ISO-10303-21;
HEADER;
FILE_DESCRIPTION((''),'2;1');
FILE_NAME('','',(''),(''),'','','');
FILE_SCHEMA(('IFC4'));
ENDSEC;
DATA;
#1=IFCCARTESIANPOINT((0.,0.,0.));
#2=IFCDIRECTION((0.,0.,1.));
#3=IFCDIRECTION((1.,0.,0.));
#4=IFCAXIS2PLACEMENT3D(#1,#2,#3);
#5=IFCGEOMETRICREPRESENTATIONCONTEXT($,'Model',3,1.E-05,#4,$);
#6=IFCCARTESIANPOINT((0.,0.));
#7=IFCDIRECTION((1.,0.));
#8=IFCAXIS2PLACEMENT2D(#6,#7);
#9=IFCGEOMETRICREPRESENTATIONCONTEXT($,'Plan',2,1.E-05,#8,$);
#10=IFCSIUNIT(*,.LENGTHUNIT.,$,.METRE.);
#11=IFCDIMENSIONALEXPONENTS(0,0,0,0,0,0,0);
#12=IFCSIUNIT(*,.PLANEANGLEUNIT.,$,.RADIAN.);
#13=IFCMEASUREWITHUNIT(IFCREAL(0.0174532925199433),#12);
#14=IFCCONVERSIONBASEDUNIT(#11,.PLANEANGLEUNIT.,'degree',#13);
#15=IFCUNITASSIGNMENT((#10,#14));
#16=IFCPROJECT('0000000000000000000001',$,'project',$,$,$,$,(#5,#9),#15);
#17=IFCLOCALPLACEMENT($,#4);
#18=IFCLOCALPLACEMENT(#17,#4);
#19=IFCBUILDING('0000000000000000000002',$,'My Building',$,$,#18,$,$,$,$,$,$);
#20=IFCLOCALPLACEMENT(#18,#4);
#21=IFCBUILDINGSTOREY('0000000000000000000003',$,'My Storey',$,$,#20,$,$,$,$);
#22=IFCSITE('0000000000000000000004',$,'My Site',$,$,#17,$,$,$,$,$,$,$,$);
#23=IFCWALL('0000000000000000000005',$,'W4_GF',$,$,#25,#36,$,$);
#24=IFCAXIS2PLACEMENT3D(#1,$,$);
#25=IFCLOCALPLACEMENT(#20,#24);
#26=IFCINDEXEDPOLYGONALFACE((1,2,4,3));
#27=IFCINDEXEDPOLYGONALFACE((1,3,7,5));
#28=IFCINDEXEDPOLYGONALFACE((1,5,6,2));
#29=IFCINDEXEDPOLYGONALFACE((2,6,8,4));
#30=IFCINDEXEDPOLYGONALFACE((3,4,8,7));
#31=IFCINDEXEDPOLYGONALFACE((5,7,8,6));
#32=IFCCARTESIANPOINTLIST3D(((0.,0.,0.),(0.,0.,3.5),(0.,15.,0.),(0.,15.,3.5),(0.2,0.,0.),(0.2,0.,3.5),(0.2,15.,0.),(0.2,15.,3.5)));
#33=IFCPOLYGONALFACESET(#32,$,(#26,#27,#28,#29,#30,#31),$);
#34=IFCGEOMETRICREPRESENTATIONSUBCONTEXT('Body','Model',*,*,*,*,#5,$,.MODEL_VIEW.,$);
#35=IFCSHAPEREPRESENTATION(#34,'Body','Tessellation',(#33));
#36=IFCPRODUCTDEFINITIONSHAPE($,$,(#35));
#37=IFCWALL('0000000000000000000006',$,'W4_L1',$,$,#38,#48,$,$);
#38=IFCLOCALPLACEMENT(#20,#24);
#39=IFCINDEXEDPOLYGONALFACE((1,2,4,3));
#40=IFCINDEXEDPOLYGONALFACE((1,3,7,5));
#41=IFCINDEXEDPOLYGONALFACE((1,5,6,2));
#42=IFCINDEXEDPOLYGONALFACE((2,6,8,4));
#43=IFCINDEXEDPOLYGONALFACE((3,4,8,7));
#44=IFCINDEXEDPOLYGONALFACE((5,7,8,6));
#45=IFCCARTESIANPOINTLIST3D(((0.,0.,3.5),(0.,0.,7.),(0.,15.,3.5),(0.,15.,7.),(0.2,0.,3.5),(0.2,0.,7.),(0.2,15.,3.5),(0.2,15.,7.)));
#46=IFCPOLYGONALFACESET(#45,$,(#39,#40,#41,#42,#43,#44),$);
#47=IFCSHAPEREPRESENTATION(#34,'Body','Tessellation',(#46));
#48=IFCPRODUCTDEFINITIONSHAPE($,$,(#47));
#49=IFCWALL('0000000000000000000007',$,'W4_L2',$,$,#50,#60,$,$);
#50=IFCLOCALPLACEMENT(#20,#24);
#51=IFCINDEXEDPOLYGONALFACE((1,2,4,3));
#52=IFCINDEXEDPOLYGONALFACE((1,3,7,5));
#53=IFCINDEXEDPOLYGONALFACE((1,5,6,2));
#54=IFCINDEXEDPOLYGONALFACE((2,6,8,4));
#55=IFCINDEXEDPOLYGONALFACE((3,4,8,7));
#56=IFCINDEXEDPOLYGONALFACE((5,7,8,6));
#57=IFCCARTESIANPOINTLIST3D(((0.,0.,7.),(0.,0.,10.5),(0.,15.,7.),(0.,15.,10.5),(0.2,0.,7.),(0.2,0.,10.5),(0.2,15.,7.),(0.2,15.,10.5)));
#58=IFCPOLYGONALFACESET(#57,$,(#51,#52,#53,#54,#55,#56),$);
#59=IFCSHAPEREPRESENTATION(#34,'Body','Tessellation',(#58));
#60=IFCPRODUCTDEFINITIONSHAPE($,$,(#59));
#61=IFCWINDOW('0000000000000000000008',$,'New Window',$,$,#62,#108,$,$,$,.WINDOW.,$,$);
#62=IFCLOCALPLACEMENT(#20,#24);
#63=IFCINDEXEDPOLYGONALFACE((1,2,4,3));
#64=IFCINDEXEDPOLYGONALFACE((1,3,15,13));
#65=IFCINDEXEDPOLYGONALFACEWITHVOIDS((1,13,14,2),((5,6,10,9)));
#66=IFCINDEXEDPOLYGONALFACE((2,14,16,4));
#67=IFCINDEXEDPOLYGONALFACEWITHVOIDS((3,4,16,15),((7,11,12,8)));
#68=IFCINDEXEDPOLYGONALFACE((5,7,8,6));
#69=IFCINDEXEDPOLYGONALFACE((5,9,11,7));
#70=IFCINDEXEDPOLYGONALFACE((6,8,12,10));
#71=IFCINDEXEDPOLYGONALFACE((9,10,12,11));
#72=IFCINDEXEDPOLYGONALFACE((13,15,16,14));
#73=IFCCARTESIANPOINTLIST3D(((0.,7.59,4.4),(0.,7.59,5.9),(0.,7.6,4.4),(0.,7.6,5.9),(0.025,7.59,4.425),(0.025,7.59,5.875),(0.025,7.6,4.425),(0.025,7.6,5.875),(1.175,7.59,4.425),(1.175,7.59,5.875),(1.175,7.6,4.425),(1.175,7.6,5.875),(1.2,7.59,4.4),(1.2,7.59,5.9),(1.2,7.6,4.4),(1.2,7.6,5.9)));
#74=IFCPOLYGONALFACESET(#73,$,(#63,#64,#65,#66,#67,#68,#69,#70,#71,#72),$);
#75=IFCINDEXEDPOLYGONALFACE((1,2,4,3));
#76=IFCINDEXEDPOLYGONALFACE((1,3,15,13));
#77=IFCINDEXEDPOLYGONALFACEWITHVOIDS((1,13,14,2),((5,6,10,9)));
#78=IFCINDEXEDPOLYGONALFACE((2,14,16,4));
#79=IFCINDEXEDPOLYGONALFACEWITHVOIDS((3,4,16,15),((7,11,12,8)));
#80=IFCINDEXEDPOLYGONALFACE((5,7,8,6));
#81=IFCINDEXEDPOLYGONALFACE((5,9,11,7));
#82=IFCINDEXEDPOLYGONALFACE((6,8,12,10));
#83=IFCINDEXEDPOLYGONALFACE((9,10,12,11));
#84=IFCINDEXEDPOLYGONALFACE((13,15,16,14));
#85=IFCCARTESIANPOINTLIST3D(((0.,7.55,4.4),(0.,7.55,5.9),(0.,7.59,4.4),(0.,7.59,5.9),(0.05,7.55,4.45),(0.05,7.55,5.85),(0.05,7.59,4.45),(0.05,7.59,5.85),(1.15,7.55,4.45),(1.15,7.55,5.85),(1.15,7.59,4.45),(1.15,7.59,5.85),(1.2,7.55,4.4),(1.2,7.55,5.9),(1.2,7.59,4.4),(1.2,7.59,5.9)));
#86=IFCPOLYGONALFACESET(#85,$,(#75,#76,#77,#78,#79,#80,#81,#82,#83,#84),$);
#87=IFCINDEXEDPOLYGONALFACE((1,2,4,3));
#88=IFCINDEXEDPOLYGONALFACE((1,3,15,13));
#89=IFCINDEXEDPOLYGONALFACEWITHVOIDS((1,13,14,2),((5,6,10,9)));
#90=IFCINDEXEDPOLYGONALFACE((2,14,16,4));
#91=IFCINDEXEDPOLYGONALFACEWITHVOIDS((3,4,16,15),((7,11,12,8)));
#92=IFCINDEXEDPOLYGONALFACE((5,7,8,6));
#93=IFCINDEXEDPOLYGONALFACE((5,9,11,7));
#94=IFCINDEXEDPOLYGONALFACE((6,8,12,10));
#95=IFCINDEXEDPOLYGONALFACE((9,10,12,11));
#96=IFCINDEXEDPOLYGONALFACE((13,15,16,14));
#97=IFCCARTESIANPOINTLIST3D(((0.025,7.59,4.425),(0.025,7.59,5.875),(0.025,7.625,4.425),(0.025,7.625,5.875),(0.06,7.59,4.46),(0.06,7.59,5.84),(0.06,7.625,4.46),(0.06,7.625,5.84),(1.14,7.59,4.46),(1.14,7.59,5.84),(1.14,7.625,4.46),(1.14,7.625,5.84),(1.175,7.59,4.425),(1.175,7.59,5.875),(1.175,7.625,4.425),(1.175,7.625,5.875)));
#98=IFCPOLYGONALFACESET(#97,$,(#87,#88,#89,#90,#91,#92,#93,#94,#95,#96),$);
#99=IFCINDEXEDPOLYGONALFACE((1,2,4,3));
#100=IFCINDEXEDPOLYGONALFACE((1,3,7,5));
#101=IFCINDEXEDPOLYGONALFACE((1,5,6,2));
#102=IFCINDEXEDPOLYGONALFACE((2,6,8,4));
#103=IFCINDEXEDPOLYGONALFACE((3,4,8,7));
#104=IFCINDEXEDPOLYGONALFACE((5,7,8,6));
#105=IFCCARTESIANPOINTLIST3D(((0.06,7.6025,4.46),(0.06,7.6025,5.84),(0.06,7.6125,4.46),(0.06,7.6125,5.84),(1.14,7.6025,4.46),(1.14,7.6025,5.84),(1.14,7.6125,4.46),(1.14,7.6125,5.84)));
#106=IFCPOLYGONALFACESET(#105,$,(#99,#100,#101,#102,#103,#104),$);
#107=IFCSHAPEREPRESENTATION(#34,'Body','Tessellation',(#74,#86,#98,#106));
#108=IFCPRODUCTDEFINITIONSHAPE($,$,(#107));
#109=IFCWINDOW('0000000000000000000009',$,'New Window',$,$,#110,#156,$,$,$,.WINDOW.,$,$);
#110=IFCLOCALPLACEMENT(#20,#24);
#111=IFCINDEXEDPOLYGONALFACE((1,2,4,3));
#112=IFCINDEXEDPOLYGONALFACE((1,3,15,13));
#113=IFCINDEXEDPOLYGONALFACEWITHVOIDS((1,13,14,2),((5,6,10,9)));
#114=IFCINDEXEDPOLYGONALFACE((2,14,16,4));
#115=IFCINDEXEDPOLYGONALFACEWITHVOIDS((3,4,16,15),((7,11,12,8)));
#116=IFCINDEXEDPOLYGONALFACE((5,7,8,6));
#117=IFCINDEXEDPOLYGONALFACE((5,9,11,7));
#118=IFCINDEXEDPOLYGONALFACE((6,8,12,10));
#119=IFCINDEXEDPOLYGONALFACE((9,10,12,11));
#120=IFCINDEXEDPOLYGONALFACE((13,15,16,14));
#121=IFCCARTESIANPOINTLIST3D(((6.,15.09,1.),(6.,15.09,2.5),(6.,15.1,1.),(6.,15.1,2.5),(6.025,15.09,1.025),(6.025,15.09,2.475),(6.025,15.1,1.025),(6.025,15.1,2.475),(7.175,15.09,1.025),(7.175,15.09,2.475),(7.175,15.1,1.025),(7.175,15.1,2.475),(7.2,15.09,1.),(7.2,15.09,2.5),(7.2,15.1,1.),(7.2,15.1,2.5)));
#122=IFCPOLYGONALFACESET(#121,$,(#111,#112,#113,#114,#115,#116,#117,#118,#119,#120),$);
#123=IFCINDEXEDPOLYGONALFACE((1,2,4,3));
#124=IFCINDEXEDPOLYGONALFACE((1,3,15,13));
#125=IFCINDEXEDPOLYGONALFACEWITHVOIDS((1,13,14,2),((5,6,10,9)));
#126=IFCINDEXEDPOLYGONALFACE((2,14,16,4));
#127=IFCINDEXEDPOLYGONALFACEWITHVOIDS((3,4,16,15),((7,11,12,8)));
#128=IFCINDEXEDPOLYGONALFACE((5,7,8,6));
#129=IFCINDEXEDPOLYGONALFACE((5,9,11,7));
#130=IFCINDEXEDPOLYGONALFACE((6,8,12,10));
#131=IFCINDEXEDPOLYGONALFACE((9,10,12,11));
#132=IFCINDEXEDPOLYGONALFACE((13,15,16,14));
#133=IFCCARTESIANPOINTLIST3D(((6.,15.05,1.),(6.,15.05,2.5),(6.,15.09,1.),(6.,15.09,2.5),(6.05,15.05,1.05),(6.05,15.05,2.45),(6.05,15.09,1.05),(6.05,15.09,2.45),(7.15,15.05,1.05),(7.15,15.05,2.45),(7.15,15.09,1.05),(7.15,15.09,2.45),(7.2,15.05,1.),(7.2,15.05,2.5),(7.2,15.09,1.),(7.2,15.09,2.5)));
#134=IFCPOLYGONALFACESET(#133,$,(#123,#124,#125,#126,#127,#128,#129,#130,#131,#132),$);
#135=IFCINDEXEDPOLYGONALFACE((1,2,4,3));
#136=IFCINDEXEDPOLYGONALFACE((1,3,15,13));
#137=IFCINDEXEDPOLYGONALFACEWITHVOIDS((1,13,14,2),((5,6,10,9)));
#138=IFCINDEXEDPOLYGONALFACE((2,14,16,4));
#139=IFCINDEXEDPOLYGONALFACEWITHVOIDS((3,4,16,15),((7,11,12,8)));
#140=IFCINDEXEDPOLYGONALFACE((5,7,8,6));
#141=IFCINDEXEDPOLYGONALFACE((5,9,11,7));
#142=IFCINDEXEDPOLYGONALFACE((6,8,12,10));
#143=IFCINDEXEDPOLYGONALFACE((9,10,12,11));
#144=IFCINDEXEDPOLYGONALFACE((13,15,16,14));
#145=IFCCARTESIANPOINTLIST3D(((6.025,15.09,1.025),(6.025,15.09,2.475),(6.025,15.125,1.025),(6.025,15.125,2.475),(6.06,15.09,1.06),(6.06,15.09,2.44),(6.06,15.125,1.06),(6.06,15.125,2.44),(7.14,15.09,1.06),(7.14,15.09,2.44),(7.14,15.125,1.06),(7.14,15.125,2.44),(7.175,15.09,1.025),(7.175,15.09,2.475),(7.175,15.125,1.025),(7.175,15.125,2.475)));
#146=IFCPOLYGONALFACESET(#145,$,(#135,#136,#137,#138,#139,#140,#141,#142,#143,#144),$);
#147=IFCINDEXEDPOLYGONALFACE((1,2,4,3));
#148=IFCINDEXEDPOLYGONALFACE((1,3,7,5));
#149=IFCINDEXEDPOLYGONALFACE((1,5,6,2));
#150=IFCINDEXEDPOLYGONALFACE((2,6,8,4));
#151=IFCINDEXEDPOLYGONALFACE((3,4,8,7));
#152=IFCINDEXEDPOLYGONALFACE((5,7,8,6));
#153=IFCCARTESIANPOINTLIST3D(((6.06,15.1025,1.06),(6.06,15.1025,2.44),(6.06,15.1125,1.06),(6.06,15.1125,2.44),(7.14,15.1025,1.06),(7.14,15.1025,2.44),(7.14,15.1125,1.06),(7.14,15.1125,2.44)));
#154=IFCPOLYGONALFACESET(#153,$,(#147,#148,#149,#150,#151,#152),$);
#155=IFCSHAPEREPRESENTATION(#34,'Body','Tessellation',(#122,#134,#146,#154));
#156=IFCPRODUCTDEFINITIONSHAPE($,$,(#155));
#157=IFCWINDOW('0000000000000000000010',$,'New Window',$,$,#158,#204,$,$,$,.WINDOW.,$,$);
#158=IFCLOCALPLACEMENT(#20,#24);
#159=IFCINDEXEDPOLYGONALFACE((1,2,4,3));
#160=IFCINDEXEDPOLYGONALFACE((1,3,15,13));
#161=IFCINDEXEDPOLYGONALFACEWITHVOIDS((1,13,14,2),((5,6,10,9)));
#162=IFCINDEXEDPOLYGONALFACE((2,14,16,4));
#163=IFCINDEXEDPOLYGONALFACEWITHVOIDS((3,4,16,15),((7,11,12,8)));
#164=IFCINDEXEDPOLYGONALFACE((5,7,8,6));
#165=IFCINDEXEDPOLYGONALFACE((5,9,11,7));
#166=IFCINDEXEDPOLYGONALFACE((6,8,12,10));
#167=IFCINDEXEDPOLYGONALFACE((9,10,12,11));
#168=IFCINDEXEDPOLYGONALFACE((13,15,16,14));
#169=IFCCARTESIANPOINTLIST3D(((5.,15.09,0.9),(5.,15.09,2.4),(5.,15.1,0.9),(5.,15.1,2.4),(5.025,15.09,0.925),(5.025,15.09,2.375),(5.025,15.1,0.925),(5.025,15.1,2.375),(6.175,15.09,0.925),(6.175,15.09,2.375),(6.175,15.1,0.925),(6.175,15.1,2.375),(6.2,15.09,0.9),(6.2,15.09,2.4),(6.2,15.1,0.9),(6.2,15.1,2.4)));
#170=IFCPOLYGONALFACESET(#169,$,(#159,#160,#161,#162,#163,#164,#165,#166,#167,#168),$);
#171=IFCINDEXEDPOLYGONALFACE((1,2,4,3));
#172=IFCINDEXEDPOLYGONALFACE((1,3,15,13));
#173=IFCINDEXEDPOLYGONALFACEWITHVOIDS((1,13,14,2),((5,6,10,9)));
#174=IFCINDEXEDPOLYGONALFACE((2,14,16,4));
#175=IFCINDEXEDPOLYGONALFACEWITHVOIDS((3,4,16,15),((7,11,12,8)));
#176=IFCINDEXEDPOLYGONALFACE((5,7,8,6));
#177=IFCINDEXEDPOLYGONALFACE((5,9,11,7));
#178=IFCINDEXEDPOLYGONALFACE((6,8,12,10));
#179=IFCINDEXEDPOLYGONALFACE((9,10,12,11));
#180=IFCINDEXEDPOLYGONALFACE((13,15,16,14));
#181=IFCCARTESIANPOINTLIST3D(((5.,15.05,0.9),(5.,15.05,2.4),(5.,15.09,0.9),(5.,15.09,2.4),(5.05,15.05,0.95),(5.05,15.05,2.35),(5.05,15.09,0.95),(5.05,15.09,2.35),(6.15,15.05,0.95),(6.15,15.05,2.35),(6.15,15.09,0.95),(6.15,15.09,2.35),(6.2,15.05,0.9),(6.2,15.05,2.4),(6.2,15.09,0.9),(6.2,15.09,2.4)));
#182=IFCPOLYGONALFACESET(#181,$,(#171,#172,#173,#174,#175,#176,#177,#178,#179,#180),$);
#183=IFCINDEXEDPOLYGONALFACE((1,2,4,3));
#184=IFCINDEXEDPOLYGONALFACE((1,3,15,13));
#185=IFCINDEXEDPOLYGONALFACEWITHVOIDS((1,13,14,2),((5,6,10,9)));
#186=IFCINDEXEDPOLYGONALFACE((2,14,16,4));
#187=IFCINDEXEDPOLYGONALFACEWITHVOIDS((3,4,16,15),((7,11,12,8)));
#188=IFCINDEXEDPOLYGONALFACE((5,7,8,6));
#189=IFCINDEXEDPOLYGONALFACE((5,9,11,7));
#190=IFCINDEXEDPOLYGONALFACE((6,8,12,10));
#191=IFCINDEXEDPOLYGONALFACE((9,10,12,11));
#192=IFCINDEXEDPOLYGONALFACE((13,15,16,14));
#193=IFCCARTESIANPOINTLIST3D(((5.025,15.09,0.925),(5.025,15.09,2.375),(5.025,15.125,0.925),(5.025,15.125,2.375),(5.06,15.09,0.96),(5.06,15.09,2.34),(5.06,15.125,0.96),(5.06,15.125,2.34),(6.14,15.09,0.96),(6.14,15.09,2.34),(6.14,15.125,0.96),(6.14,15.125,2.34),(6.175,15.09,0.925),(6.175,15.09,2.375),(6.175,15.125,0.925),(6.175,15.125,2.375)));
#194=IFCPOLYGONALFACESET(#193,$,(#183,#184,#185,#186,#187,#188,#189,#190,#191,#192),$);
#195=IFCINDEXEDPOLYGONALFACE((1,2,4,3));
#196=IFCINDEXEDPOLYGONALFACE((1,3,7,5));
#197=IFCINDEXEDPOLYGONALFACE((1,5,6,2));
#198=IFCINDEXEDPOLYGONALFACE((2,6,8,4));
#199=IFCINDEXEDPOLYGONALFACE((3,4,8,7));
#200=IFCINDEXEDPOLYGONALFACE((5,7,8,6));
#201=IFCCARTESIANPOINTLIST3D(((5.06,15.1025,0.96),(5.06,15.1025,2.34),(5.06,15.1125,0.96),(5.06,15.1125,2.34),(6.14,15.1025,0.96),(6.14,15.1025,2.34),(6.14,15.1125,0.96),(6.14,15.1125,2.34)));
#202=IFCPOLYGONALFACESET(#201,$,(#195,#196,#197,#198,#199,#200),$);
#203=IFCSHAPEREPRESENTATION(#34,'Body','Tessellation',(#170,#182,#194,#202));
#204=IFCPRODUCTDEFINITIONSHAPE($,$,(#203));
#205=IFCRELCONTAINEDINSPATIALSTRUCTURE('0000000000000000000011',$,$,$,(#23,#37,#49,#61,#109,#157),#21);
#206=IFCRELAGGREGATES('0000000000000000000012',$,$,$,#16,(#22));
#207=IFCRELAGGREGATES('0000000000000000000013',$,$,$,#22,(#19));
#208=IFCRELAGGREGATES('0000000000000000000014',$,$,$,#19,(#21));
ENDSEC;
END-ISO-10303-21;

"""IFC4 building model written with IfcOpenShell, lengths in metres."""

from ifc_helpers import new_model, entity, si_unit, converted_unit, frame, origin_with_axes, origin_2d_with_axis, place, context, subcontext, project, spatial, line, indexed_curve, outline, extrude, element, save


model = new_model("IFC4")

# Units and contexts
model_context = context("Model", 3, precision=1e-05, world=origin_with_axes())
plan_context = context("Plan", 2, precision=1e-05, world=origin_2d_with_axis())
body_context = subcontext(model_context, "Body", "Model", "MODEL_VIEW")
ifc_project = project(units=[si_unit("LENGTHUNIT", "METRE"), converted_unit("PLANEANGLEUNIT", "degree", entity("IfcReal", 0.0174532925199433), si_unit("PLANEANGLEUNIT", "RADIAN"), dimensions=[0, 0, 0, 0, 0, 0, 0])], contexts=[model_context, plan_context])

# Site, building, storey
site_placement = place(None, origin_with_axes())
site = spatial("IfcSite", under=ifc_project, at=site_placement, Name="My Site")
building_placement = place(site_placement, origin_with_axes())
building = spatial("IfcBuilding", under=site, at=building_placement, Name="My Building")
storey_placement = place(building_placement, origin_with_axes())
storey = spatial("IfcBuildingStorey", under=building, at=storey_placement, Name="My Storey")

# Walls
for number, where, z_axis, x_axis, name in (
    (1, (0.0, 15.0, 0.0), (0.0, 0.0, 1.0), (0.0, -1.0, 0.0), "W4_GF"),
    (2, (0.0, 15.0, 3.5), (0.0, 0.0, 1.0), (0.0, -1.0, 0.0), "W4_L1"),
    (3, (0.0, 15.0, 7.0), (0.0, 0.0, 1.0), (0.0, -1.0, 0.0), "W4_L2"),
):
    element("IfcWall", number, at=place(storey_placement, frame(where, z_axis=z_axis, x_axis=x_axis)), inside=storey, Name=name, context=body_context, shape_type="SweptSolid", body=[
        extrude(outline(indexed_curve([(0.0, 0.0), (0.0, 0.2), (15.0, 0.2), (15.0, 0.0), (0.0, 0.0)], self_intersect=False)), origin_with_axes(), (0.0, 0.0, 1.0), 3.5),
    ])

# Window
window_1_placement = place(storey_placement, frame((0.0, 7.5, 4.4), z_axis=(0.0, 0.0, 1.0), x_axis=(1.0, 0.0, 0.0)))
element("IfcWindow", 4, at=window_1_placement, inside=storey, Name="New Window", PredefinedType="WINDOW", context=body_context, shape_type="SweptSolid", body=[
    extrude(outline(indexed_curve([(0.0, 0.0), (1.2, 0.0), (1.2, 1.5), (0.0, 1.5)], segments=[line(1, 2, 3, 4, 1)]), holes=[indexed_curve([(0.025, 0.025), (1.175, 0.025), (1.175, 1.475), (0.025, 1.475)], segments=[line(1, 2, 3, 4, 1)])]), frame((0.0, 0.09, 0.0), z_axis=(0.0, -1.0, 0.0), x_axis=(1.0, 0.0, 0.0)), (0.0, 0.0, -1.0), 0.01),
    extrude(outline(indexed_curve([(0.0, 0.0), (1.2, 0.0), (1.2, 1.5), (0.0, 1.5)], segments=[line(1, 2, 3, 4, 1)]), holes=[indexed_curve([(0.05, 0.05), (1.15, 0.05), (1.15, 1.45), (0.05, 1.45)], segments=[line(1, 2, 3, 4, 1)])]), frame((0.0, 0.05, 0.0), z_axis=(0.0, -1.0, 0.0), x_axis=(1.0, 0.0, 0.0)), (0.0, 0.0, -1.0), 0.04),
    extrude(outline(indexed_curve([(0.0, 0.0), (1.15, 0.0), (1.15, 1.45), (0.0, 1.45)], segments=[line(1, 2, 3, 4, 1)]), holes=[indexed_curve([(0.035, 0.035), (1.115, 0.035), (1.115, 1.415), (0.035, 1.415)], segments=[line(1, 2, 3, 4, 1)])]), frame((0.025, 0.09, 0.025), z_axis=(0.0, -1.0, 0.0), x_axis=(1.0, 0.0, 0.0)), (0.0, 0.0, -1.0), 0.035),
    extrude(outline(indexed_curve([(0.035, 0.035), (1.115, 0.035), (1.115, 1.415), (0.035, 1.415)], segments=[line(1, 2, 3, 4, 1)])), frame((0.025, 0.1025, 0.025), z_axis=(0.0, -1.0, 0.0), x_axis=(1.0, 0.0, 0.0)), (0.0, 0.0, -1.0), 0.01),
])

# Window
window_2_placement = place(storey_placement, frame((6.0, 15.0, 1.0), z_axis=(0.0, 0.0, 1.0), x_axis=(1.0, 0.0, 0.0)))
element("IfcWindow", 5, at=window_2_placement, inside=storey, Name="New Window", PredefinedType="WINDOW", context=body_context, shape_type="SweptSolid", body=[
    extrude(outline(indexed_curve([(0.0, 0.0), (1.2, 0.0), (1.2, 1.5), (0.0, 1.5)], segments=[line(1, 2, 3, 4, 1)]), holes=[indexed_curve([(0.025, 0.025), (1.175, 0.025), (1.175, 1.475), (0.025, 1.475)], segments=[line(1, 2, 3, 4, 1)])]), frame((0.0, 0.09, 0.0), z_axis=(0.0, -1.0, 0.0), x_axis=(1.0, 0.0, 0.0)), (0.0, 0.0, -1.0), 0.01),
    extrude(outline(indexed_curve([(0.0, 0.0), (1.2, 0.0), (1.2, 1.5), (0.0, 1.5)], segments=[line(1, 2, 3, 4, 1)]), holes=[indexed_curve([(0.05, 0.05), (1.15, 0.05), (1.15, 1.45), (0.05, 1.45)], segments=[line(1, 2, 3, 4, 1)])]), frame((0.0, 0.05, 0.0), z_axis=(0.0, -1.0, 0.0), x_axis=(1.0, 0.0, 0.0)), (0.0, 0.0, -1.0), 0.04),
    extrude(outline(indexed_curve([(0.0, 0.0), (1.15, 0.0), (1.15, 1.45), (0.0, 1.45)], segments=[line(1, 2, 3, 4, 1)]), holes=[indexed_curve([(0.035, 0.035), (1.115, 0.035), (1.115, 1.415), (0.035, 1.415)], segments=[line(1, 2, 3, 4, 1)])]), frame((0.025, 0.09, 0.025), z_axis=(0.0, -1.0, 0.0), x_axis=(1.0, 0.0, 0.0)), (0.0, 0.0, -1.0), 0.035),
    extrude(outline(indexed_curve([(0.035, 0.035), (1.115, 0.035), (1.115, 1.415), (0.035, 1.415)], segments=[line(1, 2, 3, 4, 1)])), frame((0.025, 0.1025, 0.025), z_axis=(0.0, -1.0, 0.0), x_axis=(1.0, 0.0, 0.0)), (0.0, 0.0, -1.0), 0.01),
])

# Window
for number, where, z_axis, x_axis, name in (
    (6, (5.0, 15.0, 0.9), (0.0, 0.0, 1.0), (1.0, 0.0, 0.0), "New Window"),
):
    element("IfcWindow", number, at=place(storey_placement, frame(where, z_axis=z_axis, x_axis=x_axis)), inside=storey, Name=name, PredefinedType="WINDOW", context=body_context, shape_type="SweptSolid", body=[
        extrude(outline(indexed_curve([(0.0, 0.0), (1.2, 0.0), (1.2, 1.5), (0.0, 1.5)], segments=[line(1, 2, 3, 4, 1)]), holes=[indexed_curve([(0.025, 0.025), (1.175, 0.025), (1.175, 1.475), (0.025, 1.475)], segments=[line(1, 2, 3, 4, 1)])]), frame((0.0, 0.09, 0.0), z_axis=(0.0, -1.0, 0.0), x_axis=(1.0, 0.0, 0.0)), (0.0, 0.0, -1.0), 0.01),
        extrude(outline(indexed_curve([(0.0, 0.0), (1.2, 0.0), (1.2, 1.5), (0.0, 1.5)], segments=[line(1, 2, 3, 4, 1)]), holes=[indexed_curve([(0.05, 0.05), (1.15, 0.05), (1.15, 1.45), (0.05, 1.45)], segments=[line(1, 2, 3, 4, 1)])]), frame((0.0, 0.05, 0.0), z_axis=(0.0, -1.0, 0.0), x_axis=(1.0, 0.0, 0.0)), (0.0, 0.0, -1.0), 0.04),
        extrude(outline(indexed_curve([(0.0, 0.0), (1.15, 0.0), (1.15, 1.45), (0.0, 1.45)], segments=[line(1, 2, 3, 4, 1)]), holes=[indexed_curve([(0.035, 0.035), (1.115, 0.035), (1.115, 1.415), (0.035, 1.415)], segments=[line(1, 2, 3, 4, 1)])]), frame((0.025, 0.09, 0.025), z_axis=(0.0, -1.0, 0.0), x_axis=(1.0, 0.0, 0.0)), (0.0, 0.0, -1.0), 0.035),
        extrude(outline(indexed_curve([(0.035, 0.035), (1.115, 0.035), (1.115, 1.415), (0.035, 1.415)], segments=[line(1, 2, 3, 4, 1)])), frame((0.025, 0.1025, 0.025), z_axis=(0.0, -1.0, 0.0), x_axis=(1.0, 0.0, 0.0)), (0.0, 0.0, -1.0), 0.01),
    ])

save(model, "model.ifc")
